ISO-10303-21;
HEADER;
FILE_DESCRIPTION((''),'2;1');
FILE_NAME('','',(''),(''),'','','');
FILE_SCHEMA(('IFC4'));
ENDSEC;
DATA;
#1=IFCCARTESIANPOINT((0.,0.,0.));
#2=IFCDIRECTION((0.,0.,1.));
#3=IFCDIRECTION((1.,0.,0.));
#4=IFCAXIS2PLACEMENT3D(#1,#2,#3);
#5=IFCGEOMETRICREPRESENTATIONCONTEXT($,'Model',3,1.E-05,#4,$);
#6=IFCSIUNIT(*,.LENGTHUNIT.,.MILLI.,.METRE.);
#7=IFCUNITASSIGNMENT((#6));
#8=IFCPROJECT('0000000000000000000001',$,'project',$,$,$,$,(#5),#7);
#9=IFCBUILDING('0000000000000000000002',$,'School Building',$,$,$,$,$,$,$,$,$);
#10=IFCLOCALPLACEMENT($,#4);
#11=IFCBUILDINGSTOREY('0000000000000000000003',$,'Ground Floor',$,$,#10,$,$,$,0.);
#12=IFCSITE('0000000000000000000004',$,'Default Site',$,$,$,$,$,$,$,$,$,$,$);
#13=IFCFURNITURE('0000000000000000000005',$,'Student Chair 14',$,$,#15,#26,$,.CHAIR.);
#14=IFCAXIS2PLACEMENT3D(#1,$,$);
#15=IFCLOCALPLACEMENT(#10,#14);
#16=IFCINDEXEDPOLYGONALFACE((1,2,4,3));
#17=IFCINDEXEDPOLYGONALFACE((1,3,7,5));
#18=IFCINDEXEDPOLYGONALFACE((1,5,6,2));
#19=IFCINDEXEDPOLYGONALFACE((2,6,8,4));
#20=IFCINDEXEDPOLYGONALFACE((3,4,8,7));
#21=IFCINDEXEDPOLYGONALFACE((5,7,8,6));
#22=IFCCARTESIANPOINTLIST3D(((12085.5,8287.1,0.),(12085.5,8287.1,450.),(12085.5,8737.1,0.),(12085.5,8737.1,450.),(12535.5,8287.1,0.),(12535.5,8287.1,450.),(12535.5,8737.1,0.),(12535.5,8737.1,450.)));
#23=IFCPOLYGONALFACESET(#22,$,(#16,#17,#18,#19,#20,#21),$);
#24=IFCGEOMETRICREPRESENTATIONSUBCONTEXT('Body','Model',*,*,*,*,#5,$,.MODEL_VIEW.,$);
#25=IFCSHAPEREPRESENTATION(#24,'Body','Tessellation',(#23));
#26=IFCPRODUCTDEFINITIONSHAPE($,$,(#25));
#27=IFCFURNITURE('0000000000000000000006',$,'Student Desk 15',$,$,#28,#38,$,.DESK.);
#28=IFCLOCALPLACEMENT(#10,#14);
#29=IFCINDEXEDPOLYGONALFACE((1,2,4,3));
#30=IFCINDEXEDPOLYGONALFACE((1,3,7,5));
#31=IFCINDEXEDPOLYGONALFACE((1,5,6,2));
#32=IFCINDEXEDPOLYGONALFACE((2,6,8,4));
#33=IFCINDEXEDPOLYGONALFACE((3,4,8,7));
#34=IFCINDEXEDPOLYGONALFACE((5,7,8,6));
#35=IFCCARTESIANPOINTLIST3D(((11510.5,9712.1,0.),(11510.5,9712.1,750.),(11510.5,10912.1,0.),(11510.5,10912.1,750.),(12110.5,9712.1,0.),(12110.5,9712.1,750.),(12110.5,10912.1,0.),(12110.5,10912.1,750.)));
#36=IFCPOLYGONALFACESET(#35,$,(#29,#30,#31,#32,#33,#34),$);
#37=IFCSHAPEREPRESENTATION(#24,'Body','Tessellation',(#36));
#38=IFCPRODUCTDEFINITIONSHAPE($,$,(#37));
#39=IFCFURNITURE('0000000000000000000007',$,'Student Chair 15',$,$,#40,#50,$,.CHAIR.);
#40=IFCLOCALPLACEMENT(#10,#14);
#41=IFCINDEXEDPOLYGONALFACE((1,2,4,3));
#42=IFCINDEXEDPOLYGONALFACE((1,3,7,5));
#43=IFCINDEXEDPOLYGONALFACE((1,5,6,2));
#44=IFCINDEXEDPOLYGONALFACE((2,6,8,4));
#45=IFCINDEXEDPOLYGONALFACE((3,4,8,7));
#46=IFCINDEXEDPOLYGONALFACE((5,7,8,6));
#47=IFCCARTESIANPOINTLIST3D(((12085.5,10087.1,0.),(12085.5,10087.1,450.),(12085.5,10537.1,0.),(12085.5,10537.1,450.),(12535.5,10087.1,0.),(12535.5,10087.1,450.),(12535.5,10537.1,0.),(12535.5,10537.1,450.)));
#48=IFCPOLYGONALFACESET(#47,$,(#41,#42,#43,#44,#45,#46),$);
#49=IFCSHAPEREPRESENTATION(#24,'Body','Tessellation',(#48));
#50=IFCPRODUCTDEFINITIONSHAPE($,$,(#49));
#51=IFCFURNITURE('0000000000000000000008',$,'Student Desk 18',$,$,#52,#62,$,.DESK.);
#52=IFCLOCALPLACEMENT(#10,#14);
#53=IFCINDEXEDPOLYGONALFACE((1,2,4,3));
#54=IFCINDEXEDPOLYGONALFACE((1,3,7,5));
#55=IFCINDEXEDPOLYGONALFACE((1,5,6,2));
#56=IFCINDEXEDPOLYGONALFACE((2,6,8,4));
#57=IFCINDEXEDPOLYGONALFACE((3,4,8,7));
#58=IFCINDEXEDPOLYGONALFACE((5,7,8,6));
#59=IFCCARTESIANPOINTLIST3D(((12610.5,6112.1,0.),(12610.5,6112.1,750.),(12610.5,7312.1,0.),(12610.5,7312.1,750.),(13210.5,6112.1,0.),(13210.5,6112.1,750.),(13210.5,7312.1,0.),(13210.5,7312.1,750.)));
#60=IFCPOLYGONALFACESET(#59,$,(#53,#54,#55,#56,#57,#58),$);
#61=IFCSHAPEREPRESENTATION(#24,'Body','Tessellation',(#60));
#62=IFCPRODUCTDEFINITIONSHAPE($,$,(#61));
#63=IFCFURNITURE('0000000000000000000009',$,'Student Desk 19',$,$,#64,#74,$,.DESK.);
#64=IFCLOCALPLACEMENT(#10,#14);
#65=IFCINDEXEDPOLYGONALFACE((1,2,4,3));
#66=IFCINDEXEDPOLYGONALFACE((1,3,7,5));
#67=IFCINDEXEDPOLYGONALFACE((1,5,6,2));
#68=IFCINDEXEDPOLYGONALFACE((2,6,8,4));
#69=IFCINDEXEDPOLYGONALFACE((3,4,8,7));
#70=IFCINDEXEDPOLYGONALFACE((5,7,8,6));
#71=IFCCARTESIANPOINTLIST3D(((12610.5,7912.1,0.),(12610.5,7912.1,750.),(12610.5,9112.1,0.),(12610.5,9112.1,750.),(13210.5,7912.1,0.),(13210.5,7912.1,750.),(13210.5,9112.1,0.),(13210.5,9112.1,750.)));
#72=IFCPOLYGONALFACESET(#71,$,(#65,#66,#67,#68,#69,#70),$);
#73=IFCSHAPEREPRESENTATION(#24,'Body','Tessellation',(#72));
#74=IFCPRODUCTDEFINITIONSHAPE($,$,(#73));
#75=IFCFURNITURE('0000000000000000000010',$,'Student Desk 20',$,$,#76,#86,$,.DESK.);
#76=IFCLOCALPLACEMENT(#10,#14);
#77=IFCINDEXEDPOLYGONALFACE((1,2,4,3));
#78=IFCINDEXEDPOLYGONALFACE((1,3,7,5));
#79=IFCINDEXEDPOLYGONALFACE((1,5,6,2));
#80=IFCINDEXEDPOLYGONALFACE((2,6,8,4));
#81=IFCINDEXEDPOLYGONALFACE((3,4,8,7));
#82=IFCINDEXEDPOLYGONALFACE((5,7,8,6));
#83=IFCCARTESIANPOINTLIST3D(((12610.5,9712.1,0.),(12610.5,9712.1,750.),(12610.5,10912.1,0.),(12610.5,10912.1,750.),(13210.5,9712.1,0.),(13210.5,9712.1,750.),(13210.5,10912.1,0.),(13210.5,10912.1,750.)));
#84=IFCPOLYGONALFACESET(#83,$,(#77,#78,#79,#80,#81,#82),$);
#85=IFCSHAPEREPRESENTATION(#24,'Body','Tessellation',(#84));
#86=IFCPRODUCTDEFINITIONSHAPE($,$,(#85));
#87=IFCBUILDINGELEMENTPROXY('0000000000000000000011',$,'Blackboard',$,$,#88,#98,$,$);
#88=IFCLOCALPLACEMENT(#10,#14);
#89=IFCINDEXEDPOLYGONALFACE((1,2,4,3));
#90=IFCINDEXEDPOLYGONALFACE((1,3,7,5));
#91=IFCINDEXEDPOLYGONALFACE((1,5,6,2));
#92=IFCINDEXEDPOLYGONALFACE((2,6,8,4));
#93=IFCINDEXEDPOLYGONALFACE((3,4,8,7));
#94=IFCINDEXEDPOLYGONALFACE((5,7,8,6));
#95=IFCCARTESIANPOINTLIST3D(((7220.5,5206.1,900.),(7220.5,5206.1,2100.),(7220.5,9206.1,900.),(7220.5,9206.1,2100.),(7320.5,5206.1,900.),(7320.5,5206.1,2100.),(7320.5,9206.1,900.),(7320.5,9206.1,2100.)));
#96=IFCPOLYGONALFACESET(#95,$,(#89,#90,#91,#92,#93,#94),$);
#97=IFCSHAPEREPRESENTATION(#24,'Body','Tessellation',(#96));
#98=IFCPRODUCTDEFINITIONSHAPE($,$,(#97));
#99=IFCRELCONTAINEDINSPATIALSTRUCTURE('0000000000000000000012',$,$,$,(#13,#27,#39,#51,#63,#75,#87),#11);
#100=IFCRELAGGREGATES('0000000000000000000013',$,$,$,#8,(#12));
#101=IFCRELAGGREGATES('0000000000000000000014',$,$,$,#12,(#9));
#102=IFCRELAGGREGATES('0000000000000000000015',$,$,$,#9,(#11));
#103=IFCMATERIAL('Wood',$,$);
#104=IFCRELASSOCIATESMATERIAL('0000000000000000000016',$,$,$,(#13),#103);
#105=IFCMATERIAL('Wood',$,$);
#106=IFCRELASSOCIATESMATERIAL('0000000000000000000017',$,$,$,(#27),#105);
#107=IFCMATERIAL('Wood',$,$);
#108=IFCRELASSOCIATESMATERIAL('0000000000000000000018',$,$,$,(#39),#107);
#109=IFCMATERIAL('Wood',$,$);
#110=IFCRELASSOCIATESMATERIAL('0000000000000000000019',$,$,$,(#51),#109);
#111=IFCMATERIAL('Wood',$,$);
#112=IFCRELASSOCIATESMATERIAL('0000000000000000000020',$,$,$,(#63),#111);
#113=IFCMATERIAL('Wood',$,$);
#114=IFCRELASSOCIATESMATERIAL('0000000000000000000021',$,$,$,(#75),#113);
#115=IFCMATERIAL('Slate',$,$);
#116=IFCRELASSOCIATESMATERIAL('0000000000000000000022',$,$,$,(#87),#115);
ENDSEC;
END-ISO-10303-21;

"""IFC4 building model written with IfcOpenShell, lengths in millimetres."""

from ifc_helpers import new_model, si_unit, frame, origin_with_axes, origin_2d, place, context, subcontext, project, spatial, rectangle, extrude, material, element, save


model = new_model("IFC4")

# Units and contexts
model_context = context("Model", 3, precision=1e-05, world=origin_with_axes())
body_context = subcontext(model_context, "Body", "Model", "MODEL_VIEW")
ifc_project = project(units=[si_unit("LENGTHUNIT", "METRE", prefix="MILLI")], contexts=[model_context])

# Site, building, storey
site = spatial("IfcSite", under=ifc_project, Name="Default Site")
building = spatial("IfcBuilding", under=site, Name="School Building")
storey_placement = place(None, origin_with_axes())
storey = spatial("IfcBuildingStorey", under=building, at=storey_placement, Name="Ground Floor", Elevation=0.0)

# Furniture
ifc_material_1 = material(Name="Wood")
furniture_1_placement = place(storey_placement, frame((12310.5, 8512.1, 0.0), z_axis=(0.0, 0.0, 1.0), x_axis=(1.0, 0.0, 0.0)))
element("IfcFurniture", 1, at=furniture_1_placement, inside=storey, material=ifc_material_1, Name="Student Chair 14", PredefinedType="CHAIR", context=body_context, shape_type="SweptSolid", body=[
    extrude(rectangle(XDim=450.0, YDim=450.0, at=origin_2d()), origin_with_axes(), (0.0, 0.0, 1.0), 450.0),
])
ifc_material_2 = material(Name="Wood")
furniture_2_placement = place(storey_placement, frame((11810.5, 10312.1, 0.0), z_axis=(0.0, 0.0, 1.0), x_axis=(0.0, 1.0, 0.0)))
element("IfcFurniture", 2, at=furniture_2_placement, inside=storey, material=ifc_material_2, Name="Student Desk 15", PredefinedType="DESK", context=body_context, shape_type="SweptSolid", body=[
    extrude(rectangle(XDim=1200.0, YDim=600.0, at=origin_2d()), origin_with_axes(), (0.0, 0.0, 1.0), 750.0),
])
ifc_material_3 = material(Name="Wood")
furniture_3_placement = place(storey_placement, frame((12310.5, 10312.1, 0.0), z_axis=(0.0, 0.0, 1.0), x_axis=(1.0, 0.0, 0.0)))
element("IfcFurniture", 3, at=furniture_3_placement, inside=storey, material=ifc_material_3, Name="Student Chair 15", PredefinedType="CHAIR", context=body_context, shape_type="SweptSolid", body=[
    extrude(rectangle(XDim=450.0, YDim=450.0, at=origin_2d()), origin_with_axes(), (0.0, 0.0, 1.0), 450.0),
])
ifc_material_4 = material(Name="Wood")
furniture_4_placement = place(storey_placement, frame((12910.5, 6712.1, 0.0), z_axis=(0.0, 0.0, 1.0), x_axis=(0.0, 1.0, 0.0)))
element("IfcFurniture", 4, at=furniture_4_placement, inside=storey, material=ifc_material_4, Name="Student Desk 18", PredefinedType="DESK", context=body_context, shape_type="SweptSolid", body=[
    extrude(rectangle(XDim=1200.0, YDim=600.0, at=origin_2d()), origin_with_axes(), (0.0, 0.0, 1.0), 750.0),
])
ifc_material_5 = material(Name="Wood")
furniture_5_placement = place(storey_placement, frame((12910.5, 8512.1, 0.0), z_axis=(0.0, 0.0, 1.0), x_axis=(0.0, 1.0, 0.0)))
element("IfcFurniture", 5, at=furniture_5_placement, inside=storey, material=ifc_material_5, Name="Student Desk 19", PredefinedType="DESK", context=body_context, shape_type="SweptSolid", body=[
    extrude(rectangle(XDim=1200.0, YDim=600.0, at=origin_2d()), origin_with_axes(), (0.0, 0.0, 1.0), 750.0),
])
ifc_material_6 = material(Name="Wood")
furniture_6_placement = place(storey_placement, frame((12910.5, 10312.1, 0.0), z_axis=(0.0, 0.0, 1.0), x_axis=(0.0, 1.0, 0.0)))
element("IfcFurniture", 6, at=furniture_6_placement, inside=storey, material=ifc_material_6, Name="Student Desk 20", PredefinedType="DESK", context=body_context, shape_type="SweptSolid", body=[
    extrude(rectangle(XDim=1200.0, YDim=600.0, at=origin_2d()), origin_with_axes(), (0.0, 0.0, 1.0), 750.0),
])

# Building element proxy
ifc_material_7 = material(Name="Slate")
proxy_placement = place(storey_placement, frame((7270.5, 7206.1, 900.0), z_axis=(0.0, 0.0, 1.0), x_axis=(1.0, 0.0, 0.0)))
element("IfcBuildingElementProxy", 7, at=proxy_placement, inside=storey, material=ifc_material_7, Name="Blackboard", context=body_context, shape_type="SweptSolid", body=[
    extrude(rectangle(XDim=100.0, YDim=4000.0, at=origin_2d()), origin_with_axes(), (0.0, 0.0, 1.0), 1200.0),
])

save(model, "model.ifc")
